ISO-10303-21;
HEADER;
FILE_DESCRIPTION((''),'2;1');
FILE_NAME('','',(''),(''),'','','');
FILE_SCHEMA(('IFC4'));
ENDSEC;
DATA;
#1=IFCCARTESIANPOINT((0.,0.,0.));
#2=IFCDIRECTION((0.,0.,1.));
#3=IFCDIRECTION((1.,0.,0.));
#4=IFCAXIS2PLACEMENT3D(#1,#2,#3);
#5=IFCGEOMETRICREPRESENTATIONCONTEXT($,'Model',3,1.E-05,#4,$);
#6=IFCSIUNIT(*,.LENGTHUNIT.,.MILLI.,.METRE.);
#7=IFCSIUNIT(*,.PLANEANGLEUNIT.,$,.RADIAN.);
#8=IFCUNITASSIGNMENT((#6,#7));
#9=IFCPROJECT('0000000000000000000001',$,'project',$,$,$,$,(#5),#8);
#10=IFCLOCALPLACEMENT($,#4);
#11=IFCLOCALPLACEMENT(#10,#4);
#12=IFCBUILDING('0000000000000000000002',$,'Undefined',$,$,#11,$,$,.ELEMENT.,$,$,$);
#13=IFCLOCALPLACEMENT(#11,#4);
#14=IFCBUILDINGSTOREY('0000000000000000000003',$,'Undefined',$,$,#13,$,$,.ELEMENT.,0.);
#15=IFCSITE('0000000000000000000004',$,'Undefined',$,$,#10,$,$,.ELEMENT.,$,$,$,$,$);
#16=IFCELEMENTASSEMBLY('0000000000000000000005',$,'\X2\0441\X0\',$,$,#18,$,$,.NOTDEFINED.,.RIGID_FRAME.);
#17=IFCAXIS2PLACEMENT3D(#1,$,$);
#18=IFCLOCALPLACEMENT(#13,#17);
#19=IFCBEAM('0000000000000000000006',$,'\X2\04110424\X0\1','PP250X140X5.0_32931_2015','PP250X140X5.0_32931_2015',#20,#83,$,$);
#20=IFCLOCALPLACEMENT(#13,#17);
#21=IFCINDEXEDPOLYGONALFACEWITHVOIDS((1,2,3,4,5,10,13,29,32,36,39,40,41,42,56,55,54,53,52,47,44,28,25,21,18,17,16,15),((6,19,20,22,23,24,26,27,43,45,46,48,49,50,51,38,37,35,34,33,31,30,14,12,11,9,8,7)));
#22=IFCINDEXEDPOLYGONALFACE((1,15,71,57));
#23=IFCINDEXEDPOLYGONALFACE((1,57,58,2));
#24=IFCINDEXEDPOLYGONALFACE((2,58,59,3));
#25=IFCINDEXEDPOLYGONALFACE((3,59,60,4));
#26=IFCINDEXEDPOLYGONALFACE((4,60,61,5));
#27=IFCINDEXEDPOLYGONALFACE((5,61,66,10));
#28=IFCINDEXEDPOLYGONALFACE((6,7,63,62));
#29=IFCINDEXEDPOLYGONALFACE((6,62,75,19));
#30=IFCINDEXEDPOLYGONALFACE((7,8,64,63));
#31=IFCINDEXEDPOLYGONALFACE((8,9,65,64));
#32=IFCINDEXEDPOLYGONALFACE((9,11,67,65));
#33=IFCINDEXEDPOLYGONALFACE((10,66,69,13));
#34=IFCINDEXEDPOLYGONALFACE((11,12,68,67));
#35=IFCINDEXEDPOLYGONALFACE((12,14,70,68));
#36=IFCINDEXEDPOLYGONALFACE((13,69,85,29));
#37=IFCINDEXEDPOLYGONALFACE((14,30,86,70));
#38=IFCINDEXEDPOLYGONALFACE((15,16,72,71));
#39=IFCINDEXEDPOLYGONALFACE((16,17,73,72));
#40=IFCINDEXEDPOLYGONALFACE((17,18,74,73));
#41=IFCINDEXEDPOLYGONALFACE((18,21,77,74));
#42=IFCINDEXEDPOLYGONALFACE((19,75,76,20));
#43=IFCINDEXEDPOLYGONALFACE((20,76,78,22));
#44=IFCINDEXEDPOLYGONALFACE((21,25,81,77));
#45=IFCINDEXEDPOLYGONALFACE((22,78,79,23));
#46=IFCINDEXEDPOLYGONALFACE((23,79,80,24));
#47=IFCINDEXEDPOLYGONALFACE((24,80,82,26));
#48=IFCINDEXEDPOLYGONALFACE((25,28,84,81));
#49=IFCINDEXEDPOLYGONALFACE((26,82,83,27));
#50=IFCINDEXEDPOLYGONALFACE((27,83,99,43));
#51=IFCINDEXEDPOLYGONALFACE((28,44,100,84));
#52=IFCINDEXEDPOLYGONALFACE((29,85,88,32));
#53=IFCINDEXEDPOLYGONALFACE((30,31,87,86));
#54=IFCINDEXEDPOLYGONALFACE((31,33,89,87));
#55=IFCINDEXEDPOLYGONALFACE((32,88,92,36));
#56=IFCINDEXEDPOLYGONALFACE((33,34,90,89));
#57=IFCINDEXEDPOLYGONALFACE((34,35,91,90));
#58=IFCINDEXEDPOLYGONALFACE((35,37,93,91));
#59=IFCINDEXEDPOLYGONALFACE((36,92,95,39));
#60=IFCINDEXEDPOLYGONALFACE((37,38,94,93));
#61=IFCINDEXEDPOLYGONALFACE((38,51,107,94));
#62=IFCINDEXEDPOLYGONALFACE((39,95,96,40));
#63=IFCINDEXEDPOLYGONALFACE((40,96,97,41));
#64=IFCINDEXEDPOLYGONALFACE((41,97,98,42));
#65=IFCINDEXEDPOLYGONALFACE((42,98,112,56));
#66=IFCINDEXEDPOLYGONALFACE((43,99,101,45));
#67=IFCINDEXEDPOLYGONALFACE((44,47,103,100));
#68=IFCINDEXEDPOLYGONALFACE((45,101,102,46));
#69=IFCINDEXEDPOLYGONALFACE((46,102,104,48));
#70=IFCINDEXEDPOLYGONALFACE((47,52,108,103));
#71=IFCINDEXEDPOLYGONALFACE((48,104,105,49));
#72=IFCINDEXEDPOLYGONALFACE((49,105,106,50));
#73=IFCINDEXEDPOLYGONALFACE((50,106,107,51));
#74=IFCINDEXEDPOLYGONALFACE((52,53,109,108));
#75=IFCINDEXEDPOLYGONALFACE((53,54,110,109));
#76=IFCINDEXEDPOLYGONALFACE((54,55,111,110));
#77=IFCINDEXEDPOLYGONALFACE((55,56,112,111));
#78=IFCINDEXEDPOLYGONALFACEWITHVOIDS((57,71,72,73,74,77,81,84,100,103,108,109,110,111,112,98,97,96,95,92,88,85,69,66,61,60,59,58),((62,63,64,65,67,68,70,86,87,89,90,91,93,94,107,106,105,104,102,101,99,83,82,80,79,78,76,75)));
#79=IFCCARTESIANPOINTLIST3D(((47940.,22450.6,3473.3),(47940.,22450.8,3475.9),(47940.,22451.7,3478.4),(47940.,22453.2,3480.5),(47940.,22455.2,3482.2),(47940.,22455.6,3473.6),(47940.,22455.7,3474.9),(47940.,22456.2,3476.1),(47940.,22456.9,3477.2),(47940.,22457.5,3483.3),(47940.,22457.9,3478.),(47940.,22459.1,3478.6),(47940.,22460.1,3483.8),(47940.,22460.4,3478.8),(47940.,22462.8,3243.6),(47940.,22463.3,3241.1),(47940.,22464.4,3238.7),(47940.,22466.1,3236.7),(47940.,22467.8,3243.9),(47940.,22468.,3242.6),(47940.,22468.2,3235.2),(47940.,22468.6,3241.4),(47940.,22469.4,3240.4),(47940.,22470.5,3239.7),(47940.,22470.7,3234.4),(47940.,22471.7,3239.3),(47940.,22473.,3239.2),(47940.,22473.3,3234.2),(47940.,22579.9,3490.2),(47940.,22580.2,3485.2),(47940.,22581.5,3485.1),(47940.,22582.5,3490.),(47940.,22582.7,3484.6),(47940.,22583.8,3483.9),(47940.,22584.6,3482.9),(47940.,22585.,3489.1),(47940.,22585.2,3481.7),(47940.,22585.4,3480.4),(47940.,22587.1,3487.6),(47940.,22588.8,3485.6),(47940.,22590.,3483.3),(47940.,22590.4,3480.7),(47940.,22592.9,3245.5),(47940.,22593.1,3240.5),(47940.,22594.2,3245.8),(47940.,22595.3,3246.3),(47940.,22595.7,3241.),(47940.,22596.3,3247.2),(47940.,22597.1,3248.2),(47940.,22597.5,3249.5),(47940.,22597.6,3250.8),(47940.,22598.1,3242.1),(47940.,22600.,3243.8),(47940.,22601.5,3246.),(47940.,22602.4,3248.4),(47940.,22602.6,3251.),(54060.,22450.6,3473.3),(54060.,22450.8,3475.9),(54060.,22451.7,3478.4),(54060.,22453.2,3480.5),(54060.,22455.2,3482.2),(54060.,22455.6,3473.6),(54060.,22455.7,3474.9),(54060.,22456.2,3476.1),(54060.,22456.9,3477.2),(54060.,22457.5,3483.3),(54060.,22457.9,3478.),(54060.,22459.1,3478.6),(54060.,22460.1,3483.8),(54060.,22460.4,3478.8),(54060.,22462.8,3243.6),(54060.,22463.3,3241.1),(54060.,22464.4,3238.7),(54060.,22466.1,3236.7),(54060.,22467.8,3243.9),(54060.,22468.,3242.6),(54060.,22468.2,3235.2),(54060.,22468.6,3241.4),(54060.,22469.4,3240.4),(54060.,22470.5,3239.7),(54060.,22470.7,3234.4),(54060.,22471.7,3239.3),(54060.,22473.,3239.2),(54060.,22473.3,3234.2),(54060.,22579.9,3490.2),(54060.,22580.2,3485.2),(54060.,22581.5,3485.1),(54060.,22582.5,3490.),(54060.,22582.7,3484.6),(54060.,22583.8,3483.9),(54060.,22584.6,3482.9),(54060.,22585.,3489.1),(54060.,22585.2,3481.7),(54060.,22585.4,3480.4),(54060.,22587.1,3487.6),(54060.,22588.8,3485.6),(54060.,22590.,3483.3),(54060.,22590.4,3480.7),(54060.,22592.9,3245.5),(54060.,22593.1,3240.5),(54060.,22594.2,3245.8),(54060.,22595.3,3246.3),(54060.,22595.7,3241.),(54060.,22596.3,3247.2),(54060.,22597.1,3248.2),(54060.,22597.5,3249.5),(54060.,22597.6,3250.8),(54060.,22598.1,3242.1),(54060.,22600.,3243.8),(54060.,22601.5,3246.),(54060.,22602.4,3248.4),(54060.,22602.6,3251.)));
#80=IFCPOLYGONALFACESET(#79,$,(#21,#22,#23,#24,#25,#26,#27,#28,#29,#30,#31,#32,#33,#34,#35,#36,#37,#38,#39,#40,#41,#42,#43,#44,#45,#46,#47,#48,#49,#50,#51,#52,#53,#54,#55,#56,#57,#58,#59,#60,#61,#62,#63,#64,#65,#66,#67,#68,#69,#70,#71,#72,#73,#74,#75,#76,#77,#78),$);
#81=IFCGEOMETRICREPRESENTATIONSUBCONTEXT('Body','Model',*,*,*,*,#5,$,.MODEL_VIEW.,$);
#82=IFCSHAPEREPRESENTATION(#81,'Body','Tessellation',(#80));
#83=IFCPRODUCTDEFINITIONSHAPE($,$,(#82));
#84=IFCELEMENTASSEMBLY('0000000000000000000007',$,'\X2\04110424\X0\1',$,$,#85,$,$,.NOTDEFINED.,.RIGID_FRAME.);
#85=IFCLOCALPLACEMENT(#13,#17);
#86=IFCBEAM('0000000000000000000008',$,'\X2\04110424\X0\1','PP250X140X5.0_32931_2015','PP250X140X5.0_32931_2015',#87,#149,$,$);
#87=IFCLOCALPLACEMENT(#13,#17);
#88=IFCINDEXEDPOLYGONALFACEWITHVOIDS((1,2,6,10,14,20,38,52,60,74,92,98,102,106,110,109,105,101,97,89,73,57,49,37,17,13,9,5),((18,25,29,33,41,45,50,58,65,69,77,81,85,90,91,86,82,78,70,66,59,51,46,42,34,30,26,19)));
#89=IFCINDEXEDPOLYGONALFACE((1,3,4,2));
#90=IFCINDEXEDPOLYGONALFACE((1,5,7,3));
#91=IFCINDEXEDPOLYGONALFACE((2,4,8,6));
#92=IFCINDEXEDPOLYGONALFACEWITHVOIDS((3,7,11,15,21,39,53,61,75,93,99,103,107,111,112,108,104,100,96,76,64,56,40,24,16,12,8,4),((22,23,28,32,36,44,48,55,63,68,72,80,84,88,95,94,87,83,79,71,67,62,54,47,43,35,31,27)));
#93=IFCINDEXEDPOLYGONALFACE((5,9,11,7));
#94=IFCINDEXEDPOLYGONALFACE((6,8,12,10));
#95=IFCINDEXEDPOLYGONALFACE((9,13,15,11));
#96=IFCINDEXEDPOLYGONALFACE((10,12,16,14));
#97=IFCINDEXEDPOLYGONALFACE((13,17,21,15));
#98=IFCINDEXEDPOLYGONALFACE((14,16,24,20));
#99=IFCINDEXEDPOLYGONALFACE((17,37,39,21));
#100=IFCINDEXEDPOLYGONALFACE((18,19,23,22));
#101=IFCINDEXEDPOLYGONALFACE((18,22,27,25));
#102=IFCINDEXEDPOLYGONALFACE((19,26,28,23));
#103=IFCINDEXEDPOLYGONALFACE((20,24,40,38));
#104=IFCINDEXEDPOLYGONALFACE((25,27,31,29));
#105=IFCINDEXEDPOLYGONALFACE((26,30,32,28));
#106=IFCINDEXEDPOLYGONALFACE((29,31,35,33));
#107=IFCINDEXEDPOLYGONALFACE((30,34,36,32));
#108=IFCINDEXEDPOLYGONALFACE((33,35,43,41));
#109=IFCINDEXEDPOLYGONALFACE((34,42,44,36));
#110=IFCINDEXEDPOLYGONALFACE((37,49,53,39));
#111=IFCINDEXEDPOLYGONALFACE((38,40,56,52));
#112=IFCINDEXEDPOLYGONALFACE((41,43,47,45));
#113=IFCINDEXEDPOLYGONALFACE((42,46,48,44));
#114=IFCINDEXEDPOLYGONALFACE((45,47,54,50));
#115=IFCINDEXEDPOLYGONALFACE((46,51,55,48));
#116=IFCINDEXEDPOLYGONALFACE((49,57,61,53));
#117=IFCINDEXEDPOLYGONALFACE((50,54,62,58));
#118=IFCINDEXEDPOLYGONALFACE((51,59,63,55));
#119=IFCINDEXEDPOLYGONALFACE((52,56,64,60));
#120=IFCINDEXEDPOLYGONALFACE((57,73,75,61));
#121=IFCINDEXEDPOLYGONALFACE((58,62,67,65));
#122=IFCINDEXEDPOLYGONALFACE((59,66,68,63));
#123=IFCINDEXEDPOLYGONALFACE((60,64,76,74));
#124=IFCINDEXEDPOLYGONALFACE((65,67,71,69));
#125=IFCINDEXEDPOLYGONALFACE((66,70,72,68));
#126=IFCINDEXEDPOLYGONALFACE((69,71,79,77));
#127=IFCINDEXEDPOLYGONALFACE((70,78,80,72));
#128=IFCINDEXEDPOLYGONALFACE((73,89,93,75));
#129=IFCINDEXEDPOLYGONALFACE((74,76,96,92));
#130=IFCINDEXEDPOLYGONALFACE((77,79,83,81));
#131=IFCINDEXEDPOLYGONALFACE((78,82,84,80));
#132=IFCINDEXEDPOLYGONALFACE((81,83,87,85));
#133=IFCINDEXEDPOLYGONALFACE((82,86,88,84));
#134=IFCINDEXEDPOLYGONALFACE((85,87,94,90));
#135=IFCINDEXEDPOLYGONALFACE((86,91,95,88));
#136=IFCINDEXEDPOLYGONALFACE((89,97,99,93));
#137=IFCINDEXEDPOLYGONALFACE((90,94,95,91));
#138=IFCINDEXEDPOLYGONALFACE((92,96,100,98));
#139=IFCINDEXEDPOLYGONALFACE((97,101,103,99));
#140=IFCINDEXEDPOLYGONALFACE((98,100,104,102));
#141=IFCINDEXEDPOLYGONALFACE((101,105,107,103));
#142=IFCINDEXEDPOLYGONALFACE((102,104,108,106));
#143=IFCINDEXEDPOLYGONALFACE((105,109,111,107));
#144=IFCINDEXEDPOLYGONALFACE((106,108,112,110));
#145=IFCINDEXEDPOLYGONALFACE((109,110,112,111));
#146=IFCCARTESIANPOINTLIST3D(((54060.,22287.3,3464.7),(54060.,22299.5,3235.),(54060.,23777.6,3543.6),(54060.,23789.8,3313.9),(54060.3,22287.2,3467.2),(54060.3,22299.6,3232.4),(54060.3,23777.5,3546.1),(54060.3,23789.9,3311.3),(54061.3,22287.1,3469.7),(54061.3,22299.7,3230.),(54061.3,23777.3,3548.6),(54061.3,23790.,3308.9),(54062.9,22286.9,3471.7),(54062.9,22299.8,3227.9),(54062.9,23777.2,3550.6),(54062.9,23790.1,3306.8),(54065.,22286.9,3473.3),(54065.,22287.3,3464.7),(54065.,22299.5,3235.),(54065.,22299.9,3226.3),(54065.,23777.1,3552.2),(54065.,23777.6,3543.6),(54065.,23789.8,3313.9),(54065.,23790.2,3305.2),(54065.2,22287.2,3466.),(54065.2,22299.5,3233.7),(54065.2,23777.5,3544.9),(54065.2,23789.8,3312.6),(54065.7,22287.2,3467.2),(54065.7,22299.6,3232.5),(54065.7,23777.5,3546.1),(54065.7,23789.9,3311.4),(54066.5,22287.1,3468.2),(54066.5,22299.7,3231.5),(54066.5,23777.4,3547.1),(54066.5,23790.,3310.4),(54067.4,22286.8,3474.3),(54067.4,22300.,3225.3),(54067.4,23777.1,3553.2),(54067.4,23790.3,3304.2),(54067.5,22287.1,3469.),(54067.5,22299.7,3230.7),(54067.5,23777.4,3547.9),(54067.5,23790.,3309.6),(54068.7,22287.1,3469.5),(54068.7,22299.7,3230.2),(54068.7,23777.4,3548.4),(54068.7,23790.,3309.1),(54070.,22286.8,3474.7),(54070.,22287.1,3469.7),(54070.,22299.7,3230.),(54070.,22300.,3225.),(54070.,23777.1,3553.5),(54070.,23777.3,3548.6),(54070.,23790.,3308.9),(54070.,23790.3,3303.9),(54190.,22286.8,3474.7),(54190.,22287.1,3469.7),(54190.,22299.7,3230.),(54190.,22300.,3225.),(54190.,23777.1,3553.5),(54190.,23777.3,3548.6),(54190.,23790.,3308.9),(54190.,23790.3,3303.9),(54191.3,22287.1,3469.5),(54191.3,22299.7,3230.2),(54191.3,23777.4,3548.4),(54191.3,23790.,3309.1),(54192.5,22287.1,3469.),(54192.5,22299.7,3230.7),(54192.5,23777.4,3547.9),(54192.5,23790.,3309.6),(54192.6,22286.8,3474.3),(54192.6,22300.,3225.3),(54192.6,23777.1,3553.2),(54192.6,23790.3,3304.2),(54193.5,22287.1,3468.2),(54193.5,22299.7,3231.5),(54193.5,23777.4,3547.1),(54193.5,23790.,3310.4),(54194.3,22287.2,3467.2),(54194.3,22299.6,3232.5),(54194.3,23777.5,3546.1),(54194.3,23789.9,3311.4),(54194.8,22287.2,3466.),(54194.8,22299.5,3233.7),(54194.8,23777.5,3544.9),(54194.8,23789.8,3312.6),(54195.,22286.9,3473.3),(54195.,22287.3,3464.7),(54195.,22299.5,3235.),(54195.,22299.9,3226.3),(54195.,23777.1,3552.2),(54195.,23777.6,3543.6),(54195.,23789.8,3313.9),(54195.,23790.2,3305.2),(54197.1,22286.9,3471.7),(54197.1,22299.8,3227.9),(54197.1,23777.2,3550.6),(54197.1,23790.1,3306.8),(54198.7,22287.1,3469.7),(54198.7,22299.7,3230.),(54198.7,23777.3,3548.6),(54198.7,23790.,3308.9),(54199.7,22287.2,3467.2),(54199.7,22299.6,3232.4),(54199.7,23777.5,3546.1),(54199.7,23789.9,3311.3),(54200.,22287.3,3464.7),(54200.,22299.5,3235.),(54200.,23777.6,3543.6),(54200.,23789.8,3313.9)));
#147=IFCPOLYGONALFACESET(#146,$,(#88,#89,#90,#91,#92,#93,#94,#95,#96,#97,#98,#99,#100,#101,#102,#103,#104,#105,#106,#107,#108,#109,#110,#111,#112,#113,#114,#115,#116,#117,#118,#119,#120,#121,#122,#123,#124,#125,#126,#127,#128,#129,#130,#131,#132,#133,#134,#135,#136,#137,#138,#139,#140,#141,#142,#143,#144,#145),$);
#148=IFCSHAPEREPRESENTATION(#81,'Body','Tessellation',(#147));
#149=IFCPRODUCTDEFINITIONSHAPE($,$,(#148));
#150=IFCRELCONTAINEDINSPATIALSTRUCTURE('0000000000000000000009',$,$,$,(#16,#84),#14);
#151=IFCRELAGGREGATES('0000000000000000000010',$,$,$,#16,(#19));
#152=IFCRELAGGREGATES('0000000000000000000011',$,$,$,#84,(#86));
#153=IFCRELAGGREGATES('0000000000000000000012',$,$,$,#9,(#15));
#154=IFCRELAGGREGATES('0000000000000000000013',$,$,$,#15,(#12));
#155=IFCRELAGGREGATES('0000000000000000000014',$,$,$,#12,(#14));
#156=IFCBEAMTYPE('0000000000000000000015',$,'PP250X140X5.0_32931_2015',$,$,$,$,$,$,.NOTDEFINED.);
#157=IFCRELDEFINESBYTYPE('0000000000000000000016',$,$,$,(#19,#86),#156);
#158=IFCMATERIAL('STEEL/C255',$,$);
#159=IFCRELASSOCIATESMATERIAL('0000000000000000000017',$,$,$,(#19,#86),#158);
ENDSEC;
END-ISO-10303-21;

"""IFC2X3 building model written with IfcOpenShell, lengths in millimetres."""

from ifc_helpers import new_model, si_unit, frame, origin_with_axes, origin_2d_with_axis, place, context, subcontext, project, spatial, hollow_rectangle, extrude, material, type_object, element, aggregate, save


model = new_model("IFC2X3")

# Units and contexts
model_context = context("Model", 3, precision=1e-05, world=origin_with_axes())
body_context = subcontext(model_context, "Body", "Model", "MODEL_VIEW")
ifc_project = project(units=[si_unit("LENGTHUNIT", "METRE", prefix="MILLI"), si_unit("PLANEANGLEUNIT", "RADIAN")], contexts=[model_context])

# Site, building, storey
site_placement = place(None, origin_with_axes())
site = spatial("IfcSite", under=ifc_project, at=site_placement, Name="Undefined", CompositionType="ELEMENT")
building_placement = place(site_placement, origin_with_axes())
building = spatial("IfcBuilding", under=site, at=building_placement, Name="Undefined", CompositionType="ELEMENT")
storey_placement = place(building_placement, origin_with_axes())
storey = spatial("IfcBuildingStorey", under=building, at=storey_placement, Name="Undefined", CompositionType="ELEMENT", Elevation=0.0)

# Shared definitions
ifc_material_1 = material(Name="STEEL/C255")

# Element assemblies, beams
beam_type_1 = type_object("IfcBeamType", Name="PP250X140X5.0_32931_2015", PredefinedType="NOTDEFINED")
assembly_1_placement = place(storey_placement, origin_with_axes())
assembly_1 = element("IfcElementAssembly", 1, at=assembly_1_placement, inside=storey, Name="с", AssemblyPlace="NOTDEFINED", PredefinedType="RIGID_FRAME")
beam_1_placement = place(assembly_1_placement, frame((54060.0, 22526.6, 3362.2), z_axis=(0.0, 0.052867, -0.998602), x_axis=(-1.0, 0.0, 0.0)))
beam_1 = element("IfcBeam", 2, at=beam_1_placement, type_object=beam_type_1, material=ifc_material_1, Name="БФ1", Description="PP250X140X5.0_32931_2015", ObjectType="PP250X140X5.0_32931_2015", context=body_context, shape_type="SweptSolid", body=[
    extrude(hollow_rectangle(XDim=140.0, YDim=250.0, WallThickness=5.0, InnerFilletRadius=5.0, OuterFilletRadius=10.0, at=origin_2d_with_axis()), frame((6120.0, 0.0, 0.0), z_axis=(-1.0, 0.0, 0.0), x_axis=(0.0, -1.0, 0.0)), (0.0, 0.0, 1.0), 6120.0),
])
aggregate(assembly_1, [beam_1])
assembly_2_placement = place(storey_placement, origin_with_axes())
assembly_2 = element("IfcElementAssembly", 3, at=assembly_2_placement, inside=storey, Name="БФ1", AssemblyPlace="NOTDEFINED", PredefinedType="RIGID_FRAME")
beam_2_placement = place(assembly_2_placement, frame((54130.0, 22293.4, 3349.8), z_axis=(0.0, -0.052867, 0.998602), x_axis=(0.0, 0.998602, 0.052867)))
beam_2 = element("IfcBeam", 4, at=beam_2_placement, type_object=beam_type_1, material=ifc_material_1, Name="БФ1", Description="PP250X140X5.0_32931_2015", ObjectType="PP250X140X5.0_32931_2015", context=body_context, shape_type="SweptSolid", body=[
    extrude(hollow_rectangle(XDim=140.0, YDim=250.0, WallThickness=5.0, InnerFilletRadius=5.0, OuterFilletRadius=10.0, at=origin_2d_with_axis()), frame((1492.4, 0.0, 0.0), z_axis=(-1.0, 0.0, 0.0), x_axis=(0.0, -1.0, 0.0)), (0.0, 0.0, 1.0), 1492.4),
])
aggregate(assembly_2, [beam_2])

save(model, "model.ifc")
